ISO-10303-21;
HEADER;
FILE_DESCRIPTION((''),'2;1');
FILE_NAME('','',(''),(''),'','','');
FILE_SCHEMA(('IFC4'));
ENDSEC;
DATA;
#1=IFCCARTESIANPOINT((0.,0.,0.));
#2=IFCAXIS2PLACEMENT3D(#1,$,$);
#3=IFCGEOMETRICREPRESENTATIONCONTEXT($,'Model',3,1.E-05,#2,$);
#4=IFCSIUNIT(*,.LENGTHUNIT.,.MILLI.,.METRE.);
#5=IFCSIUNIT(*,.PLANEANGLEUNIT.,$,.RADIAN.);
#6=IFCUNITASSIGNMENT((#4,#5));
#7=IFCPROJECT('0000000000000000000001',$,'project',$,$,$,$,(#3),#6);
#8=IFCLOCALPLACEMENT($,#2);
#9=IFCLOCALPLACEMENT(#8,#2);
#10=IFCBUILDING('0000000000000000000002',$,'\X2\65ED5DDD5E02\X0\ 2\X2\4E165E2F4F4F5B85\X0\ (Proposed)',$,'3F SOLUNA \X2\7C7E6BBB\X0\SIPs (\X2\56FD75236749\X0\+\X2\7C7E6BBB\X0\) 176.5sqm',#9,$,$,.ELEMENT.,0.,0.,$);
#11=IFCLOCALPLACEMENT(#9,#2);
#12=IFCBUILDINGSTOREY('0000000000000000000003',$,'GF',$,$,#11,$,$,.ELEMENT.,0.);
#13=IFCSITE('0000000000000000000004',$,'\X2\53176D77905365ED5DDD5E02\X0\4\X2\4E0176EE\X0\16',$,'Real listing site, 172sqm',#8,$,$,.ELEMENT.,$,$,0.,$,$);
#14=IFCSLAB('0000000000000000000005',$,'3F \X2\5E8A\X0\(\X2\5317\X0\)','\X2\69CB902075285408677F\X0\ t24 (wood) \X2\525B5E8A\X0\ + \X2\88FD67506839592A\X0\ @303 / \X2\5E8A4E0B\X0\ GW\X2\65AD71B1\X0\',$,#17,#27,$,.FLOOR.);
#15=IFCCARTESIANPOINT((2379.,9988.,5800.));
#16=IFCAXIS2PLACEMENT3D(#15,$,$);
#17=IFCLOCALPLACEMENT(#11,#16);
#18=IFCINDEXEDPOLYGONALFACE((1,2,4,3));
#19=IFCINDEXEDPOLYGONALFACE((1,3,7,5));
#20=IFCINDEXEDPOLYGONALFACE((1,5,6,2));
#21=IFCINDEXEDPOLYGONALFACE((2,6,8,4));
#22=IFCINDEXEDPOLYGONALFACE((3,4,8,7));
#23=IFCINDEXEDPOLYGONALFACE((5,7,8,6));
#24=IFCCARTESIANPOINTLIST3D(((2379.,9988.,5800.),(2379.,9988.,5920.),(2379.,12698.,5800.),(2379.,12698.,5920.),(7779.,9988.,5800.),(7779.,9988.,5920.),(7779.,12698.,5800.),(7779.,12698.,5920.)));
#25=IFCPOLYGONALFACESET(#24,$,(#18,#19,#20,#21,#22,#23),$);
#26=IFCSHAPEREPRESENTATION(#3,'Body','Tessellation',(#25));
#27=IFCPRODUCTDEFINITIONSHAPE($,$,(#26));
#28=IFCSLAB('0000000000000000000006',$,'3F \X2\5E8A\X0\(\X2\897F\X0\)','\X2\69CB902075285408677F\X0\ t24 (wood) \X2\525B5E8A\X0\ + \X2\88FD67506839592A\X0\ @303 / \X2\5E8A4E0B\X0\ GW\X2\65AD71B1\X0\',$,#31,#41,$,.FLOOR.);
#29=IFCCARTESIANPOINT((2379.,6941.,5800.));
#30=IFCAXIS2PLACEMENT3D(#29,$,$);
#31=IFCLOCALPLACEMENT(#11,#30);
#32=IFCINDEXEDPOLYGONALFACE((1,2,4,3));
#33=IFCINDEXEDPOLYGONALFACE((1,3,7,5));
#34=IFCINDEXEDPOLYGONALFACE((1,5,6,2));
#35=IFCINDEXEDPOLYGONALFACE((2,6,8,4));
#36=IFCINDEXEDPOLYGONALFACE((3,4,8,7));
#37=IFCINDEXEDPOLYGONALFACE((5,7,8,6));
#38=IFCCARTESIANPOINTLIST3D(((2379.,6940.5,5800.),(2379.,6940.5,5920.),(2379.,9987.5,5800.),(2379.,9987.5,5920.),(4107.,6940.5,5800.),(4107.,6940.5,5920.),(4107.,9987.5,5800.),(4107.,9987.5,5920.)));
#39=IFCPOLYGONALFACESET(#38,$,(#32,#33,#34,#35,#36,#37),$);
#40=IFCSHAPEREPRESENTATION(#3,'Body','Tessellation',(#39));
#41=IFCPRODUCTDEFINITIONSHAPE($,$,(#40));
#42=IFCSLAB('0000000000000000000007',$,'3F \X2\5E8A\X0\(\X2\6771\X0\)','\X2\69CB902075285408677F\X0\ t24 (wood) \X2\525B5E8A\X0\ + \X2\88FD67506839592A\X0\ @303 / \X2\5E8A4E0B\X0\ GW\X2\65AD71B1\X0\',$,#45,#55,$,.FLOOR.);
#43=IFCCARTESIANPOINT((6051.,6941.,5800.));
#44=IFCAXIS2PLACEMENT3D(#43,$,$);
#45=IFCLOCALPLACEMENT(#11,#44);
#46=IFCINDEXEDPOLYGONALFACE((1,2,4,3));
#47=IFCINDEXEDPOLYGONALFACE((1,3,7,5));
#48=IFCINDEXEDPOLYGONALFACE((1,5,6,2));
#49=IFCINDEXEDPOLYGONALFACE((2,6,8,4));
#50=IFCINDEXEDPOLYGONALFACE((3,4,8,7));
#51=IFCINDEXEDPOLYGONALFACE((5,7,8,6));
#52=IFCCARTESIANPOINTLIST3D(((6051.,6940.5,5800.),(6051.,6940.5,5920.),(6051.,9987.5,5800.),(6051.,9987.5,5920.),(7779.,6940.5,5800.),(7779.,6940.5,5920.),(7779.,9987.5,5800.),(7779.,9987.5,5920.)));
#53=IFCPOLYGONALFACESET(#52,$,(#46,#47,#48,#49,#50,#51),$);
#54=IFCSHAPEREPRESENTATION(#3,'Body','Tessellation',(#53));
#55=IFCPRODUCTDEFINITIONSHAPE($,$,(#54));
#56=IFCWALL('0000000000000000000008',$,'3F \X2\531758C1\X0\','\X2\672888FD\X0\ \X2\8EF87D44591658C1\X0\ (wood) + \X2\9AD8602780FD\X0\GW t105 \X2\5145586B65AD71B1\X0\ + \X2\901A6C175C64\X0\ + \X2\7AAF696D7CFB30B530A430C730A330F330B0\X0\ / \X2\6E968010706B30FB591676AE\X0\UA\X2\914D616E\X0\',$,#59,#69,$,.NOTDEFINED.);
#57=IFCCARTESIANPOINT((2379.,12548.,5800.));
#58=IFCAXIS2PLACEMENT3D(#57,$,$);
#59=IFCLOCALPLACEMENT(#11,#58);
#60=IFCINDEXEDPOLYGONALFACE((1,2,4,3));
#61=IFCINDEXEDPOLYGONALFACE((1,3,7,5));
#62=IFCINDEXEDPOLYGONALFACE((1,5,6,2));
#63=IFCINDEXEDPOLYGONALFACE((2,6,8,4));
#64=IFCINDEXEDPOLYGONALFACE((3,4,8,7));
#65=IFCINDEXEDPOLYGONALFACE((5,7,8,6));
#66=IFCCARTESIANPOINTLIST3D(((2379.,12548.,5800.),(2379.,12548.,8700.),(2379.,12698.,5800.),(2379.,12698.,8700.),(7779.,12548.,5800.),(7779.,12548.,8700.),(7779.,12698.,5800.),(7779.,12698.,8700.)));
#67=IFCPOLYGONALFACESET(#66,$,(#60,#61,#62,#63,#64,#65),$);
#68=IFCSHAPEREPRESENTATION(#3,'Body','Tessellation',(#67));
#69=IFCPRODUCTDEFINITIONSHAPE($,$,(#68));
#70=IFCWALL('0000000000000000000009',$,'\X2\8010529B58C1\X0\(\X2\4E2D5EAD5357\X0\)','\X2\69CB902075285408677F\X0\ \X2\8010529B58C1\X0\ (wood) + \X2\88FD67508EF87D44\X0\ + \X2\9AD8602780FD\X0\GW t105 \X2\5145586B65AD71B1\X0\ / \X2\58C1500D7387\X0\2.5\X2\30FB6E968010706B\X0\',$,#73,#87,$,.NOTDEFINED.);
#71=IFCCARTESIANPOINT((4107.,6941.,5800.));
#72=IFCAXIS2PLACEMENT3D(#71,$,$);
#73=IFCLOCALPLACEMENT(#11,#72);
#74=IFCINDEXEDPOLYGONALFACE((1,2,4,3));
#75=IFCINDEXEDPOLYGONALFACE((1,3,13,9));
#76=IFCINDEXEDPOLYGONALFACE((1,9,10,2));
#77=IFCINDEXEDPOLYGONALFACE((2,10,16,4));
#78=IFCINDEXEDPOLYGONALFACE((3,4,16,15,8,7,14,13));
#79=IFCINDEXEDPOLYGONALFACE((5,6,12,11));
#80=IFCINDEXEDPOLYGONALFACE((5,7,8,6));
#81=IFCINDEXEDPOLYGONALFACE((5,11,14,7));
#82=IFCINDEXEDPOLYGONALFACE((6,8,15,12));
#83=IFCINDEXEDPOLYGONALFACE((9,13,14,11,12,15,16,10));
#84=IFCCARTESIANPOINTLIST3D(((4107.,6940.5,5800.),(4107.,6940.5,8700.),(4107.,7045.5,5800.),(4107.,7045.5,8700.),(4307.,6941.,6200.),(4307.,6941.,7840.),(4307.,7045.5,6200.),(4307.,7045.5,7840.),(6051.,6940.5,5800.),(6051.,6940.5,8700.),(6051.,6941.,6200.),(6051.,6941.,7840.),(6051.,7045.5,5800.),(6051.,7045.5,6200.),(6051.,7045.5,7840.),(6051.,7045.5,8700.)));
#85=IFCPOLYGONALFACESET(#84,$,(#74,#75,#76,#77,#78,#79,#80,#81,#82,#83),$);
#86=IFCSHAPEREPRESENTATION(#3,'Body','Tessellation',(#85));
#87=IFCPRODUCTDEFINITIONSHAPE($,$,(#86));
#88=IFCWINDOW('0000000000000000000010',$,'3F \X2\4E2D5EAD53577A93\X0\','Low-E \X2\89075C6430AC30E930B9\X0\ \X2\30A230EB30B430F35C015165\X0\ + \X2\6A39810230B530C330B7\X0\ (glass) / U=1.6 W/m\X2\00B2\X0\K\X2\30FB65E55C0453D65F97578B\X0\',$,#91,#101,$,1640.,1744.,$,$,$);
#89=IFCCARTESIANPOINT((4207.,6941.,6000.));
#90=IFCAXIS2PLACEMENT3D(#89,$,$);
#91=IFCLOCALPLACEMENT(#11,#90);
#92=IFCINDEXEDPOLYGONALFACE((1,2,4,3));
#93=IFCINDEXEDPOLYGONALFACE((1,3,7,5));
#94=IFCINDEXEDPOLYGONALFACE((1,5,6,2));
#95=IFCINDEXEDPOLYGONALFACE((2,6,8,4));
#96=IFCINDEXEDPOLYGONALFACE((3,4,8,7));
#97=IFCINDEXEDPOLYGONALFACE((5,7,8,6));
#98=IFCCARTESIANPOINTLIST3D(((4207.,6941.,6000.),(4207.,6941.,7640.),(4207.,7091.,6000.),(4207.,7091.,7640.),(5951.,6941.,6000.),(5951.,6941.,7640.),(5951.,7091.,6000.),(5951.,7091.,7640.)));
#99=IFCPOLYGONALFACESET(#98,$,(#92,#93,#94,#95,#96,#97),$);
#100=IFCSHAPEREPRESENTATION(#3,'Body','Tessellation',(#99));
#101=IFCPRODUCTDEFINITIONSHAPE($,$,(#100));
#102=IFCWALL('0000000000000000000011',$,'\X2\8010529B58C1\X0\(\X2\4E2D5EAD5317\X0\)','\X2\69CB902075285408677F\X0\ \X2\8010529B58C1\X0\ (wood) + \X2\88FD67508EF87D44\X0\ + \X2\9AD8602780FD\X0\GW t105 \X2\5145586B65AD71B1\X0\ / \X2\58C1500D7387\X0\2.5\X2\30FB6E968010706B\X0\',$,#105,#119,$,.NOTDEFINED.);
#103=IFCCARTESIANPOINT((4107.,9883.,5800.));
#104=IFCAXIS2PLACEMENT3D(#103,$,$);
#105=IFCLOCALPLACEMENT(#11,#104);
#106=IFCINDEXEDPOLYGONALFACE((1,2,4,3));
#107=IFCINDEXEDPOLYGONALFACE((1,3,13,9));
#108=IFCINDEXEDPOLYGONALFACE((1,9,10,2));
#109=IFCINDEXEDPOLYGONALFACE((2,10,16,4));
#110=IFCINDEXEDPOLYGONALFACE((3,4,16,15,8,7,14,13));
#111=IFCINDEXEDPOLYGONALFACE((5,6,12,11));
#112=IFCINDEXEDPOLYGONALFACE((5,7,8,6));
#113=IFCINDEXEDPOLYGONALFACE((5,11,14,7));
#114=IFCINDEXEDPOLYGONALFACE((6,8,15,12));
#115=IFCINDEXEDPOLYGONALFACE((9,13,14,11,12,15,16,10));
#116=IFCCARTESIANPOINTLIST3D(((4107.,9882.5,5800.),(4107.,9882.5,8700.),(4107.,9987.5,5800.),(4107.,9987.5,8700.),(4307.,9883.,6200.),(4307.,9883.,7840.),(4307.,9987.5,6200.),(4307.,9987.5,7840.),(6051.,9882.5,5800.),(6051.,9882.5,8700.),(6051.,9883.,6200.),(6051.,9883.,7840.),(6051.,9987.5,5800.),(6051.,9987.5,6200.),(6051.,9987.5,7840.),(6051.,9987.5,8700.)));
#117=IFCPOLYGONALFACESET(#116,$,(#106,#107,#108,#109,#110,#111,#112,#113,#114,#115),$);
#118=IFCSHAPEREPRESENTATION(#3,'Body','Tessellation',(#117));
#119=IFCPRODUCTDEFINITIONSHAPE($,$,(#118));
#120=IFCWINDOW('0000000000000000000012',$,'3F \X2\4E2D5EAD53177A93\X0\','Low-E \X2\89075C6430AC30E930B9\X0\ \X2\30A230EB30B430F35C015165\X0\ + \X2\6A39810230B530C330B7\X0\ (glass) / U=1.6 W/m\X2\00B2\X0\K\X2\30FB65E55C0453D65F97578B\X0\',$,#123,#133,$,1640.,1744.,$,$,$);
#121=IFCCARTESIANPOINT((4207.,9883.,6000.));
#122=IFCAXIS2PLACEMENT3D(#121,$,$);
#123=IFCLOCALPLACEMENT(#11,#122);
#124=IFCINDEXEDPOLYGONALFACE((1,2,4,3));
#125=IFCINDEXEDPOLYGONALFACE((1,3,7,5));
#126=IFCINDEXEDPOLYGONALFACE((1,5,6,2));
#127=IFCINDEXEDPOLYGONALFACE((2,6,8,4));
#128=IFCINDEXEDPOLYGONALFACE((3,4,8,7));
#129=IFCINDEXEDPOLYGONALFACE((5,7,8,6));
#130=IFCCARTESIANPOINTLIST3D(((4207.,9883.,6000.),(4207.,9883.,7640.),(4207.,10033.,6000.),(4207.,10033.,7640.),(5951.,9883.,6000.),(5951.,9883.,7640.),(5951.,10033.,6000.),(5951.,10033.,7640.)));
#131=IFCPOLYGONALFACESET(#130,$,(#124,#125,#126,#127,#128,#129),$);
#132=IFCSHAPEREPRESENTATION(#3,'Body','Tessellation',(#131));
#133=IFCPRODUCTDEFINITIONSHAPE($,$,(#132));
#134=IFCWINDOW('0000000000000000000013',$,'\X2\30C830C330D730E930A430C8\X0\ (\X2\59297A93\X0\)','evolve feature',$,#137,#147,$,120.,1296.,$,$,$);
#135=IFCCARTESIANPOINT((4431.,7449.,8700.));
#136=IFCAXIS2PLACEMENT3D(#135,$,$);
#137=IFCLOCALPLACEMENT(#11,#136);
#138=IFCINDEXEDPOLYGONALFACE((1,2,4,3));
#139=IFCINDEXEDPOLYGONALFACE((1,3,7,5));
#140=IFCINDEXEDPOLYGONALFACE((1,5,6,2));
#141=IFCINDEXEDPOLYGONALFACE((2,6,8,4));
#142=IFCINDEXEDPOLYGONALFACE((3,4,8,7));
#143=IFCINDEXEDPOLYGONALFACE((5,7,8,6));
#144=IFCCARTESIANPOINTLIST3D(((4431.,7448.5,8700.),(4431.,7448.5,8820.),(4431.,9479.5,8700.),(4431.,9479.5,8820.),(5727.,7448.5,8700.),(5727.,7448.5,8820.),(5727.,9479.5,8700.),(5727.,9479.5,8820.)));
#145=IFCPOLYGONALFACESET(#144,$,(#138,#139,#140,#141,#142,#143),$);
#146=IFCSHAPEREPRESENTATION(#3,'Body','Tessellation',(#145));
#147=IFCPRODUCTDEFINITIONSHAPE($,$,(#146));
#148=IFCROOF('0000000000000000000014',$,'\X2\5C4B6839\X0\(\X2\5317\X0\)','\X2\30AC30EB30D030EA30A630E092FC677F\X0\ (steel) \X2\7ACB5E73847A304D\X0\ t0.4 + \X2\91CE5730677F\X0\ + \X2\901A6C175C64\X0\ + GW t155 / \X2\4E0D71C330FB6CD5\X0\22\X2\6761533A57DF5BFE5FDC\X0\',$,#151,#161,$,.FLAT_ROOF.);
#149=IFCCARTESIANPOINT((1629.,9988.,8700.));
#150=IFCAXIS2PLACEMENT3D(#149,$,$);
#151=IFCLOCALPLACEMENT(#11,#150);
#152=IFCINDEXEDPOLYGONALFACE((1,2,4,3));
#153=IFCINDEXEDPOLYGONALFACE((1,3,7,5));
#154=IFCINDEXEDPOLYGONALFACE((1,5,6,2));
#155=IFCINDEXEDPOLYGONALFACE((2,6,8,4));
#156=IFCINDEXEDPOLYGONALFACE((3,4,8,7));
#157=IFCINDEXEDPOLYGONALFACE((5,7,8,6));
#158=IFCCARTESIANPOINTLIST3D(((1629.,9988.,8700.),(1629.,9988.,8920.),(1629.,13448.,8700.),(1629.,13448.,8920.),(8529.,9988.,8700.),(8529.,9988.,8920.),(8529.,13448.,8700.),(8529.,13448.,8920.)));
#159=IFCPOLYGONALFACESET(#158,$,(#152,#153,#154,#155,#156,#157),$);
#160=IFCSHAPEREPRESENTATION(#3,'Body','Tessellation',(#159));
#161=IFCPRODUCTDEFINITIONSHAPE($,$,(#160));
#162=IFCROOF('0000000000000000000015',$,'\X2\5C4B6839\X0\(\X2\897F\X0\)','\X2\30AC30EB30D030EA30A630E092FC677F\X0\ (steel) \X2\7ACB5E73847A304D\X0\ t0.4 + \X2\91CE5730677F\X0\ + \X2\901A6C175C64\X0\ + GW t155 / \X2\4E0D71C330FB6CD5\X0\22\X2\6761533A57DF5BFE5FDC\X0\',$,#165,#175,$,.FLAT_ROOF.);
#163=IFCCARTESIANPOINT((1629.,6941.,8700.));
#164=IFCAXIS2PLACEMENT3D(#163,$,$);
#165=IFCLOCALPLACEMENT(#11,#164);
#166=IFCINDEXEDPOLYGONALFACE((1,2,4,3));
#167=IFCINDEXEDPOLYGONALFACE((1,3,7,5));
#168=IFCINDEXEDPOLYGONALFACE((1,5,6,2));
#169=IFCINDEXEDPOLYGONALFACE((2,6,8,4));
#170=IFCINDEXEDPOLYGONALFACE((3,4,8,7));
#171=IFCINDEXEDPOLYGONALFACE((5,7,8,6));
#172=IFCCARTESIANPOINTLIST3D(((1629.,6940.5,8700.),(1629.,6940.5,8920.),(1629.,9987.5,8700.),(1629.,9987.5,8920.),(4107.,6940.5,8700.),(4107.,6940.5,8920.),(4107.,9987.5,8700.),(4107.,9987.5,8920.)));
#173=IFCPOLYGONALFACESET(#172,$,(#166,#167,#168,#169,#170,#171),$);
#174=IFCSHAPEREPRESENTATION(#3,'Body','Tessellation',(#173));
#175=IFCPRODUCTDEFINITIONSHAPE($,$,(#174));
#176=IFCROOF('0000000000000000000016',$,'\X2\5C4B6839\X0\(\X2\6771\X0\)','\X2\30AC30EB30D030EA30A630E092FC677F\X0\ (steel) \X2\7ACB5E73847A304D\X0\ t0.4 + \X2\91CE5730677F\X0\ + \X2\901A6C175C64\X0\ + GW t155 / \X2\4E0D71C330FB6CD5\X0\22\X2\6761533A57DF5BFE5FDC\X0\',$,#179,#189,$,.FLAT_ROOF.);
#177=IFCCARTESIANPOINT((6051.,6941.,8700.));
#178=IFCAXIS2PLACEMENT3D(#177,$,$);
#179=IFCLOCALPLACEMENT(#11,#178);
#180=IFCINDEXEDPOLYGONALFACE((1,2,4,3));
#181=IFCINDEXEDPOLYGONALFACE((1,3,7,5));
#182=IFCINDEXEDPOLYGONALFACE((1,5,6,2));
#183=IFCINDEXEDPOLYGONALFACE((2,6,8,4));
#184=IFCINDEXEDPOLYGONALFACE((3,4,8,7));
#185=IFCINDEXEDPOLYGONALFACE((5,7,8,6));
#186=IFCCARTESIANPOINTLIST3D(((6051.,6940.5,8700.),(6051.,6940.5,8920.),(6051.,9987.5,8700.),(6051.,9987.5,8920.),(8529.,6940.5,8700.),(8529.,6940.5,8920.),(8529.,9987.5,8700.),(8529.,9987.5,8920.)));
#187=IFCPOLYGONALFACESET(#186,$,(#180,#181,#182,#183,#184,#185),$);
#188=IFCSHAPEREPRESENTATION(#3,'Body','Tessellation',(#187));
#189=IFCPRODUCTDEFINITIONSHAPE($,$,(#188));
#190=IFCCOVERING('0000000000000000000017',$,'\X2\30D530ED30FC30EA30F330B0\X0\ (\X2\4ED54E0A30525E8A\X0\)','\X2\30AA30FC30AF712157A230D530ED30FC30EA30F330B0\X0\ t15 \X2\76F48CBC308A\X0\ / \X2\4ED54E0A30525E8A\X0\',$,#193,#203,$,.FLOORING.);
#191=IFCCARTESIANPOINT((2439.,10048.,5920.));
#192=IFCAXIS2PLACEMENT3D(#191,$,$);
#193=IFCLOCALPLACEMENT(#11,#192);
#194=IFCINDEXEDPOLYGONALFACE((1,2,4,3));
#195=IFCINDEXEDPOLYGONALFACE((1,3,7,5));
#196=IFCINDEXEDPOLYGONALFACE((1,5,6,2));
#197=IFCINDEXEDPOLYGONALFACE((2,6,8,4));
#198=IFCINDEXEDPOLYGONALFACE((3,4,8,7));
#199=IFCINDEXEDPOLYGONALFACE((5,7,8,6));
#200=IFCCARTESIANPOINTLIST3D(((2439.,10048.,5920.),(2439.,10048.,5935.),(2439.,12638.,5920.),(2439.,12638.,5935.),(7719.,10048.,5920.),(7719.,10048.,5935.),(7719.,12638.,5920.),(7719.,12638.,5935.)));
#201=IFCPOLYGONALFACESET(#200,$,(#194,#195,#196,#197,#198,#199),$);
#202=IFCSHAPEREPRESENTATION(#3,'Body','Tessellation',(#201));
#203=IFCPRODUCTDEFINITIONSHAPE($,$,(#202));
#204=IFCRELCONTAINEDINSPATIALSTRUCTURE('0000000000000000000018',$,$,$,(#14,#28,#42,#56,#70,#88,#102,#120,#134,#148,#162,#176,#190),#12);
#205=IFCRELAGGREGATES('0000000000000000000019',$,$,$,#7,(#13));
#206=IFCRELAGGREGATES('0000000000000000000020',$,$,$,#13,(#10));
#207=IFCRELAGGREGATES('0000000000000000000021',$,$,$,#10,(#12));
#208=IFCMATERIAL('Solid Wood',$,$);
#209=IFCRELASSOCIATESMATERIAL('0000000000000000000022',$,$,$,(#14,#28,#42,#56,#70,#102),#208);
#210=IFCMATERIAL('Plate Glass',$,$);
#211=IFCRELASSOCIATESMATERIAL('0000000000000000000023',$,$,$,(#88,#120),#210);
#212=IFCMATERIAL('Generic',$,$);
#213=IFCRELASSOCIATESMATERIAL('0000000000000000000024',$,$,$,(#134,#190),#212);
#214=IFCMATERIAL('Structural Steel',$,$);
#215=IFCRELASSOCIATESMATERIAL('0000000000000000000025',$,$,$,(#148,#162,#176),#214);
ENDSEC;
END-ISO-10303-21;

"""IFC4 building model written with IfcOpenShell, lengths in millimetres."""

from ifc_helpers import new_model, si_unit, frame, frame_2d, origin, place, context, project, spatial, rectangle, extrude, material, element, fill, save


model = new_model("IFC4")

# Units and contexts
model_context = context("Model", 3, precision=1e-05, world=origin())
ifc_project = project(units=[si_unit("LENGTHUNIT", "METRE", prefix="MILLI"), si_unit("PLANEANGLEUNIT", "RADIAN")], contexts=[model_context])

# Site, building, storey
site_placement = place(None, origin())
site = spatial("IfcSite", under=ifc_project, at=site_placement, Name="北海道旭川市4丁目16", ObjectType="Real listing site, 172sqm", CompositionType="ELEMENT", RefElevation=0.0)
building_placement = place(site_placement, origin())
building = spatial("IfcBuilding", under=site, at=building_placement, Name="旭川市 2世帯住宅 (Proposed)", ObjectType="3F SOLUNA 籾殻SIPs (国産杉+籾殻) 176.5sqm", CompositionType="ELEMENT", ElevationOfRefHeight=0.0, ElevationOfTerrain=0.0)
storey_placement = place(building_placement, origin())
storey = spatial("IfcBuildingStorey", under=building, at=storey_placement, Name="GF", CompositionType="ELEMENT", Elevation=0.0)

# Slabs
ifc_material_1 = material(Name="Solid Wood")
slab_1_placement = place(storey_placement, frame((2379.0, 9988.0, 5800.0)))
element("IfcSlab", 1, at=slab_1_placement, inside=storey, material=ifc_material_1, Name="3F 床(北)", Description="構造用合板 t24 (wood) 剛床 + 製材根太 @303 / 床下 GW断熱", PredefinedType="FLOOR", context=model_context, shape_type="SweptSolid", body=[
    extrude(rectangle(XDim=5400.0, YDim=2710.0, at=frame_2d((2700.0, 1355.0))), frame((2379.0, 9988.0, 5800.0)), (0.0, 0.0, 1.0), 120.0),
])
slab_2_placement = place(storey_placement, frame((2379.0, 6941.0, 5800.0)))
element("IfcSlab", 2, at=slab_2_placement, inside=storey, material=ifc_material_1, Name="3F 床(西)", Description="構造用合板 t24 (wood) 剛床 + 製材根太 @303 / 床下 GW断熱", PredefinedType="FLOOR", context=model_context, shape_type="SweptSolid", body=[
    extrude(rectangle(XDim=1728.0, YDim=3047.0, at=frame_2d((864.0, 1523.0))), frame((2379.0, 6941.0, 5800.0)), (0.0, 0.0, 1.0), 120.0),
])
slab_3_placement = place(storey_placement, frame((6051.0, 6941.0, 5800.0)))
element("IfcSlab", 3, at=slab_3_placement, inside=storey, material=ifc_material_1, Name="3F 床(東)", Description="構造用合板 t24 (wood) 剛床 + 製材根太 @303 / 床下 GW断熱", PredefinedType="FLOOR", context=model_context, shape_type="SweptSolid", body=[
    extrude(rectangle(XDim=1728.0, YDim=3047.0, at=frame_2d((864.0, 1523.0))), frame((6051.0, 6941.0, 5800.0)), (0.0, 0.0, 1.0), 120.0),
])

# Wall
wall_1_placement = place(storey_placement, frame((2379.0, 12548.0, 5800.0)))
element("IfcWall", 4, at=wall_1_placement, inside=storey, material=ifc_material_1, Name="3F 北壁", Description="木製 軸組外壁 (wood) + 高性能GW t105 充填断熱 + 通気層 + 窯業系サイディング / 準耐火・外皮UA配慮", PredefinedType="NOTDEFINED", context=model_context, shape_type="SweptSolid", body=[
    extrude(rectangle(XDim=5400.0, YDim=150.0, at=frame_2d((2700.0, 75.0))), frame((2379.0, 12548.0, 5800.0)), (0.0, 0.0, 1.0), 2900.0),
])

# Walls, openings, windows
wall_2_placement = place(storey_placement, frame((4107.0, 6941.0, 5800.0)))
wall_2 = element("IfcWall", 5, at=wall_2_placement, inside=storey, material=ifc_material_1, Name="耐力壁(中庭南)", Description="構造用合板 耐力壁 (wood) + 製材軸組 + 高性能GW t105 充填断熱 / 壁倍率2.5・準耐火", PredefinedType="NOTDEFINED", context=model_context, shape_type="SweptSolid", body=[
    extrude(rectangle(XDim=1944.0, YDim=105.0, at=frame_2d((972.0, 52.0))), frame((4107.0, 6941.0, 5800.0)), (0.0, 0.0, 1.0), 2900.0),
])
opening_1_placement = place(storey_placement, frame((4207.0, 6941.0, 6000.0)))
opening_1 = element("IfcOpeningElement", 6, at=opening_1_placement, cuts=wall_2, PredefinedType="NOTDEFINED", context=model_context, shape_type="SweptSolid", body=[
    extrude(rectangle(XDim=1744.0, YDim=150.0, at=frame_2d((872.0, 75.0))), frame((4207.0, 6941.0, 6000.0)), (0.0, 0.0, 1.0), 1640.0),
])
ifc_material_2 = material(Name="Plate Glass")
window_1_placement = place(storey_placement, frame((4207.0, 6941.0, 6000.0)))
window_1 = element("IfcWindow", 7, at=window_1_placement, inside=storey, material=ifc_material_2, Name="3F 中庭南窓", Description="Low-E 複層ガラス アルゴン封入 + 樹脂サッシ (glass) / U=1.6 W/m²K・日射取得型", OverallHeight=1640.0, OverallWidth=1744.0, context=model_context, shape_type="SweptSolid", body=[
    extrude(rectangle(XDim=1744.0, YDim=150.0, at=frame_2d((872.0, 75.0))), frame((4207.0, 6941.0, 6000.0)), (0.0, 0.0, 1.0), 1640.0),
])
fill(opening_1, window_1)
wall_3_placement = place(storey_placement, frame((4107.0, 9883.0, 5800.0)))
wall_3 = element("IfcWall", 8, at=wall_3_placement, inside=storey, material=ifc_material_1, Name="耐力壁(中庭北)", Description="構造用合板 耐力壁 (wood) + 製材軸組 + 高性能GW t105 充填断熱 / 壁倍率2.5・準耐火", PredefinedType="NOTDEFINED", context=model_context, shape_type="SweptSolid", body=[
    extrude(rectangle(XDim=1944.0, YDim=105.0, at=frame_2d((972.0, 52.0))), frame((4107.0, 9883.0, 5800.0)), (0.0, 0.0, 1.0), 2900.0),
])
opening_2_placement = place(storey_placement, frame((4207.0, 9883.0, 6000.0)))
opening_2 = element("IfcOpeningElement", 9, at=opening_2_placement, cuts=wall_3, PredefinedType="NOTDEFINED", context=model_context, shape_type="SweptSolid", body=[
    extrude(rectangle(XDim=1744.0, YDim=150.0, at=frame_2d((872.0, 75.0))), frame((4207.0, 9883.0, 6000.0)), (0.0, 0.0, 1.0), 1640.0),
])
window_2_placement = place(storey_placement, frame((4207.0, 9883.0, 6000.0)))
window_2 = element("IfcWindow", 10, at=window_2_placement, inside=storey, material=ifc_material_2, Name="3F 中庭北窓", Description="Low-E 複層ガラス アルゴン封入 + 樹脂サッシ (glass) / U=1.6 W/m²K・日射取得型", OverallHeight=1640.0, OverallWidth=1744.0, context=model_context, shape_type="SweptSolid", body=[
    extrude(rectangle(XDim=1744.0, YDim=150.0, at=frame_2d((872.0, 75.0))), frame((4207.0, 9883.0, 6000.0)), (0.0, 0.0, 1.0), 1640.0),
])
fill(opening_2, window_2)

# Window
ifc_material_3 = material(Name="Generic")
window_3_placement = place(storey_placement, frame((4431.0, 7449.0, 8700.0)))
element("IfcWindow", 11, at=window_3_placement, inside=storey, material=ifc_material_3, Name="トップライト (天窓)", Description="evolve feature", OverallHeight=120.0, OverallWidth=1296.0, context=model_context, shape_type="SweptSolid", body=[
    extrude(rectangle(XDim=1296.0, YDim=2031.0, at=frame_2d((648.0, 1015.0))), frame((4431.0, 7449.0, 8700.0)), (0.0, 0.0, 1.0), 120.0),
])

# Roofs
ifc_material_4 = material(Name="Structural Steel")
for number, where, name in (
    (12, (1629.0, 9988.0, 8700.0), "屋根(北)"),
):
    element("IfcRoof", number, at=place(storey_placement, frame(where)), inside=storey, material=ifc_material_4, Name=name, Description="ガルバリウム鋼板 (steel) 立平葺き t0.4 + 野地板 + 通気層 + GW t155 / 不燃・法22条区域対応", PredefinedType="FLAT_ROOF", context=model_context, shape_type="SweptSolid", body=[
        extrude(rectangle(XDim=6900.0, YDim=3460.0, at=frame_2d((3450.0, 1730.0))), frame((1629.0, 9988.0, 8700.0)), (0.0, 0.0, 1.0), 220.0),
    ])
roof_1_placement = place(storey_placement, frame((1629.0, 6941.0, 8700.0)))
element("IfcRoof", 13, at=roof_1_placement, inside=storey, material=ifc_material_4, Name="屋根(西)", Description="ガルバリウム鋼板 (steel) 立平葺き t0.4 + 野地板 + 通気層 + GW t155 / 不燃・法22条区域対応", PredefinedType="FLAT_ROOF", context=model_context, shape_type="SweptSolid", body=[
    extrude(rectangle(XDim=2478.0, YDim=3047.0, at=frame_2d((1239.0, 1523.0))), frame((1629.0, 6941.0, 8700.0)), (0.0, 0.0, 1.0), 220.0),
])
roof_2_placement = place(storey_placement, frame((6051.0, 6941.0, 8700.0)))
element("IfcRoof", 14, at=roof_2_placement, inside=storey, material=ifc_material_4, Name="屋根(東)", Description="ガルバリウム鋼板 (steel) 立平葺き t0.4 + 野地板 + 通気層 + GW t155 / 不燃・法22条区域対応", PredefinedType="FLAT_ROOF", context=model_context, shape_type="SweptSolid", body=[
    extrude(rectangle(XDim=2478.0, YDim=3047.0, at=frame_2d((1239.0, 1523.0))), frame((6051.0, 6941.0, 8700.0)), (0.0, 0.0, 1.0), 220.0),
])

# Covering
covering_1_placement = place(storey_placement, frame((2439.0, 10048.0, 5920.0)))
element("IfcCovering", 15, at=covering_1_placement, inside=storey, material=ifc_material_3, Name="フローリング (仕上げ床)", Description="オーク無垢フローリング t15 直貼り / 仕上げ床", PredefinedType="FLOORING", context=model_context, shape_type="SweptSolid", body=[
    extrude(rectangle(XDim=5280.0, YDim=2590.0, at=frame_2d((2640.0, 1295.0))), frame((2439.0, 10048.0, 5920.0)), (0.0, 0.0, 1.0), 15.0),
])

save(model, "model.ifc")
